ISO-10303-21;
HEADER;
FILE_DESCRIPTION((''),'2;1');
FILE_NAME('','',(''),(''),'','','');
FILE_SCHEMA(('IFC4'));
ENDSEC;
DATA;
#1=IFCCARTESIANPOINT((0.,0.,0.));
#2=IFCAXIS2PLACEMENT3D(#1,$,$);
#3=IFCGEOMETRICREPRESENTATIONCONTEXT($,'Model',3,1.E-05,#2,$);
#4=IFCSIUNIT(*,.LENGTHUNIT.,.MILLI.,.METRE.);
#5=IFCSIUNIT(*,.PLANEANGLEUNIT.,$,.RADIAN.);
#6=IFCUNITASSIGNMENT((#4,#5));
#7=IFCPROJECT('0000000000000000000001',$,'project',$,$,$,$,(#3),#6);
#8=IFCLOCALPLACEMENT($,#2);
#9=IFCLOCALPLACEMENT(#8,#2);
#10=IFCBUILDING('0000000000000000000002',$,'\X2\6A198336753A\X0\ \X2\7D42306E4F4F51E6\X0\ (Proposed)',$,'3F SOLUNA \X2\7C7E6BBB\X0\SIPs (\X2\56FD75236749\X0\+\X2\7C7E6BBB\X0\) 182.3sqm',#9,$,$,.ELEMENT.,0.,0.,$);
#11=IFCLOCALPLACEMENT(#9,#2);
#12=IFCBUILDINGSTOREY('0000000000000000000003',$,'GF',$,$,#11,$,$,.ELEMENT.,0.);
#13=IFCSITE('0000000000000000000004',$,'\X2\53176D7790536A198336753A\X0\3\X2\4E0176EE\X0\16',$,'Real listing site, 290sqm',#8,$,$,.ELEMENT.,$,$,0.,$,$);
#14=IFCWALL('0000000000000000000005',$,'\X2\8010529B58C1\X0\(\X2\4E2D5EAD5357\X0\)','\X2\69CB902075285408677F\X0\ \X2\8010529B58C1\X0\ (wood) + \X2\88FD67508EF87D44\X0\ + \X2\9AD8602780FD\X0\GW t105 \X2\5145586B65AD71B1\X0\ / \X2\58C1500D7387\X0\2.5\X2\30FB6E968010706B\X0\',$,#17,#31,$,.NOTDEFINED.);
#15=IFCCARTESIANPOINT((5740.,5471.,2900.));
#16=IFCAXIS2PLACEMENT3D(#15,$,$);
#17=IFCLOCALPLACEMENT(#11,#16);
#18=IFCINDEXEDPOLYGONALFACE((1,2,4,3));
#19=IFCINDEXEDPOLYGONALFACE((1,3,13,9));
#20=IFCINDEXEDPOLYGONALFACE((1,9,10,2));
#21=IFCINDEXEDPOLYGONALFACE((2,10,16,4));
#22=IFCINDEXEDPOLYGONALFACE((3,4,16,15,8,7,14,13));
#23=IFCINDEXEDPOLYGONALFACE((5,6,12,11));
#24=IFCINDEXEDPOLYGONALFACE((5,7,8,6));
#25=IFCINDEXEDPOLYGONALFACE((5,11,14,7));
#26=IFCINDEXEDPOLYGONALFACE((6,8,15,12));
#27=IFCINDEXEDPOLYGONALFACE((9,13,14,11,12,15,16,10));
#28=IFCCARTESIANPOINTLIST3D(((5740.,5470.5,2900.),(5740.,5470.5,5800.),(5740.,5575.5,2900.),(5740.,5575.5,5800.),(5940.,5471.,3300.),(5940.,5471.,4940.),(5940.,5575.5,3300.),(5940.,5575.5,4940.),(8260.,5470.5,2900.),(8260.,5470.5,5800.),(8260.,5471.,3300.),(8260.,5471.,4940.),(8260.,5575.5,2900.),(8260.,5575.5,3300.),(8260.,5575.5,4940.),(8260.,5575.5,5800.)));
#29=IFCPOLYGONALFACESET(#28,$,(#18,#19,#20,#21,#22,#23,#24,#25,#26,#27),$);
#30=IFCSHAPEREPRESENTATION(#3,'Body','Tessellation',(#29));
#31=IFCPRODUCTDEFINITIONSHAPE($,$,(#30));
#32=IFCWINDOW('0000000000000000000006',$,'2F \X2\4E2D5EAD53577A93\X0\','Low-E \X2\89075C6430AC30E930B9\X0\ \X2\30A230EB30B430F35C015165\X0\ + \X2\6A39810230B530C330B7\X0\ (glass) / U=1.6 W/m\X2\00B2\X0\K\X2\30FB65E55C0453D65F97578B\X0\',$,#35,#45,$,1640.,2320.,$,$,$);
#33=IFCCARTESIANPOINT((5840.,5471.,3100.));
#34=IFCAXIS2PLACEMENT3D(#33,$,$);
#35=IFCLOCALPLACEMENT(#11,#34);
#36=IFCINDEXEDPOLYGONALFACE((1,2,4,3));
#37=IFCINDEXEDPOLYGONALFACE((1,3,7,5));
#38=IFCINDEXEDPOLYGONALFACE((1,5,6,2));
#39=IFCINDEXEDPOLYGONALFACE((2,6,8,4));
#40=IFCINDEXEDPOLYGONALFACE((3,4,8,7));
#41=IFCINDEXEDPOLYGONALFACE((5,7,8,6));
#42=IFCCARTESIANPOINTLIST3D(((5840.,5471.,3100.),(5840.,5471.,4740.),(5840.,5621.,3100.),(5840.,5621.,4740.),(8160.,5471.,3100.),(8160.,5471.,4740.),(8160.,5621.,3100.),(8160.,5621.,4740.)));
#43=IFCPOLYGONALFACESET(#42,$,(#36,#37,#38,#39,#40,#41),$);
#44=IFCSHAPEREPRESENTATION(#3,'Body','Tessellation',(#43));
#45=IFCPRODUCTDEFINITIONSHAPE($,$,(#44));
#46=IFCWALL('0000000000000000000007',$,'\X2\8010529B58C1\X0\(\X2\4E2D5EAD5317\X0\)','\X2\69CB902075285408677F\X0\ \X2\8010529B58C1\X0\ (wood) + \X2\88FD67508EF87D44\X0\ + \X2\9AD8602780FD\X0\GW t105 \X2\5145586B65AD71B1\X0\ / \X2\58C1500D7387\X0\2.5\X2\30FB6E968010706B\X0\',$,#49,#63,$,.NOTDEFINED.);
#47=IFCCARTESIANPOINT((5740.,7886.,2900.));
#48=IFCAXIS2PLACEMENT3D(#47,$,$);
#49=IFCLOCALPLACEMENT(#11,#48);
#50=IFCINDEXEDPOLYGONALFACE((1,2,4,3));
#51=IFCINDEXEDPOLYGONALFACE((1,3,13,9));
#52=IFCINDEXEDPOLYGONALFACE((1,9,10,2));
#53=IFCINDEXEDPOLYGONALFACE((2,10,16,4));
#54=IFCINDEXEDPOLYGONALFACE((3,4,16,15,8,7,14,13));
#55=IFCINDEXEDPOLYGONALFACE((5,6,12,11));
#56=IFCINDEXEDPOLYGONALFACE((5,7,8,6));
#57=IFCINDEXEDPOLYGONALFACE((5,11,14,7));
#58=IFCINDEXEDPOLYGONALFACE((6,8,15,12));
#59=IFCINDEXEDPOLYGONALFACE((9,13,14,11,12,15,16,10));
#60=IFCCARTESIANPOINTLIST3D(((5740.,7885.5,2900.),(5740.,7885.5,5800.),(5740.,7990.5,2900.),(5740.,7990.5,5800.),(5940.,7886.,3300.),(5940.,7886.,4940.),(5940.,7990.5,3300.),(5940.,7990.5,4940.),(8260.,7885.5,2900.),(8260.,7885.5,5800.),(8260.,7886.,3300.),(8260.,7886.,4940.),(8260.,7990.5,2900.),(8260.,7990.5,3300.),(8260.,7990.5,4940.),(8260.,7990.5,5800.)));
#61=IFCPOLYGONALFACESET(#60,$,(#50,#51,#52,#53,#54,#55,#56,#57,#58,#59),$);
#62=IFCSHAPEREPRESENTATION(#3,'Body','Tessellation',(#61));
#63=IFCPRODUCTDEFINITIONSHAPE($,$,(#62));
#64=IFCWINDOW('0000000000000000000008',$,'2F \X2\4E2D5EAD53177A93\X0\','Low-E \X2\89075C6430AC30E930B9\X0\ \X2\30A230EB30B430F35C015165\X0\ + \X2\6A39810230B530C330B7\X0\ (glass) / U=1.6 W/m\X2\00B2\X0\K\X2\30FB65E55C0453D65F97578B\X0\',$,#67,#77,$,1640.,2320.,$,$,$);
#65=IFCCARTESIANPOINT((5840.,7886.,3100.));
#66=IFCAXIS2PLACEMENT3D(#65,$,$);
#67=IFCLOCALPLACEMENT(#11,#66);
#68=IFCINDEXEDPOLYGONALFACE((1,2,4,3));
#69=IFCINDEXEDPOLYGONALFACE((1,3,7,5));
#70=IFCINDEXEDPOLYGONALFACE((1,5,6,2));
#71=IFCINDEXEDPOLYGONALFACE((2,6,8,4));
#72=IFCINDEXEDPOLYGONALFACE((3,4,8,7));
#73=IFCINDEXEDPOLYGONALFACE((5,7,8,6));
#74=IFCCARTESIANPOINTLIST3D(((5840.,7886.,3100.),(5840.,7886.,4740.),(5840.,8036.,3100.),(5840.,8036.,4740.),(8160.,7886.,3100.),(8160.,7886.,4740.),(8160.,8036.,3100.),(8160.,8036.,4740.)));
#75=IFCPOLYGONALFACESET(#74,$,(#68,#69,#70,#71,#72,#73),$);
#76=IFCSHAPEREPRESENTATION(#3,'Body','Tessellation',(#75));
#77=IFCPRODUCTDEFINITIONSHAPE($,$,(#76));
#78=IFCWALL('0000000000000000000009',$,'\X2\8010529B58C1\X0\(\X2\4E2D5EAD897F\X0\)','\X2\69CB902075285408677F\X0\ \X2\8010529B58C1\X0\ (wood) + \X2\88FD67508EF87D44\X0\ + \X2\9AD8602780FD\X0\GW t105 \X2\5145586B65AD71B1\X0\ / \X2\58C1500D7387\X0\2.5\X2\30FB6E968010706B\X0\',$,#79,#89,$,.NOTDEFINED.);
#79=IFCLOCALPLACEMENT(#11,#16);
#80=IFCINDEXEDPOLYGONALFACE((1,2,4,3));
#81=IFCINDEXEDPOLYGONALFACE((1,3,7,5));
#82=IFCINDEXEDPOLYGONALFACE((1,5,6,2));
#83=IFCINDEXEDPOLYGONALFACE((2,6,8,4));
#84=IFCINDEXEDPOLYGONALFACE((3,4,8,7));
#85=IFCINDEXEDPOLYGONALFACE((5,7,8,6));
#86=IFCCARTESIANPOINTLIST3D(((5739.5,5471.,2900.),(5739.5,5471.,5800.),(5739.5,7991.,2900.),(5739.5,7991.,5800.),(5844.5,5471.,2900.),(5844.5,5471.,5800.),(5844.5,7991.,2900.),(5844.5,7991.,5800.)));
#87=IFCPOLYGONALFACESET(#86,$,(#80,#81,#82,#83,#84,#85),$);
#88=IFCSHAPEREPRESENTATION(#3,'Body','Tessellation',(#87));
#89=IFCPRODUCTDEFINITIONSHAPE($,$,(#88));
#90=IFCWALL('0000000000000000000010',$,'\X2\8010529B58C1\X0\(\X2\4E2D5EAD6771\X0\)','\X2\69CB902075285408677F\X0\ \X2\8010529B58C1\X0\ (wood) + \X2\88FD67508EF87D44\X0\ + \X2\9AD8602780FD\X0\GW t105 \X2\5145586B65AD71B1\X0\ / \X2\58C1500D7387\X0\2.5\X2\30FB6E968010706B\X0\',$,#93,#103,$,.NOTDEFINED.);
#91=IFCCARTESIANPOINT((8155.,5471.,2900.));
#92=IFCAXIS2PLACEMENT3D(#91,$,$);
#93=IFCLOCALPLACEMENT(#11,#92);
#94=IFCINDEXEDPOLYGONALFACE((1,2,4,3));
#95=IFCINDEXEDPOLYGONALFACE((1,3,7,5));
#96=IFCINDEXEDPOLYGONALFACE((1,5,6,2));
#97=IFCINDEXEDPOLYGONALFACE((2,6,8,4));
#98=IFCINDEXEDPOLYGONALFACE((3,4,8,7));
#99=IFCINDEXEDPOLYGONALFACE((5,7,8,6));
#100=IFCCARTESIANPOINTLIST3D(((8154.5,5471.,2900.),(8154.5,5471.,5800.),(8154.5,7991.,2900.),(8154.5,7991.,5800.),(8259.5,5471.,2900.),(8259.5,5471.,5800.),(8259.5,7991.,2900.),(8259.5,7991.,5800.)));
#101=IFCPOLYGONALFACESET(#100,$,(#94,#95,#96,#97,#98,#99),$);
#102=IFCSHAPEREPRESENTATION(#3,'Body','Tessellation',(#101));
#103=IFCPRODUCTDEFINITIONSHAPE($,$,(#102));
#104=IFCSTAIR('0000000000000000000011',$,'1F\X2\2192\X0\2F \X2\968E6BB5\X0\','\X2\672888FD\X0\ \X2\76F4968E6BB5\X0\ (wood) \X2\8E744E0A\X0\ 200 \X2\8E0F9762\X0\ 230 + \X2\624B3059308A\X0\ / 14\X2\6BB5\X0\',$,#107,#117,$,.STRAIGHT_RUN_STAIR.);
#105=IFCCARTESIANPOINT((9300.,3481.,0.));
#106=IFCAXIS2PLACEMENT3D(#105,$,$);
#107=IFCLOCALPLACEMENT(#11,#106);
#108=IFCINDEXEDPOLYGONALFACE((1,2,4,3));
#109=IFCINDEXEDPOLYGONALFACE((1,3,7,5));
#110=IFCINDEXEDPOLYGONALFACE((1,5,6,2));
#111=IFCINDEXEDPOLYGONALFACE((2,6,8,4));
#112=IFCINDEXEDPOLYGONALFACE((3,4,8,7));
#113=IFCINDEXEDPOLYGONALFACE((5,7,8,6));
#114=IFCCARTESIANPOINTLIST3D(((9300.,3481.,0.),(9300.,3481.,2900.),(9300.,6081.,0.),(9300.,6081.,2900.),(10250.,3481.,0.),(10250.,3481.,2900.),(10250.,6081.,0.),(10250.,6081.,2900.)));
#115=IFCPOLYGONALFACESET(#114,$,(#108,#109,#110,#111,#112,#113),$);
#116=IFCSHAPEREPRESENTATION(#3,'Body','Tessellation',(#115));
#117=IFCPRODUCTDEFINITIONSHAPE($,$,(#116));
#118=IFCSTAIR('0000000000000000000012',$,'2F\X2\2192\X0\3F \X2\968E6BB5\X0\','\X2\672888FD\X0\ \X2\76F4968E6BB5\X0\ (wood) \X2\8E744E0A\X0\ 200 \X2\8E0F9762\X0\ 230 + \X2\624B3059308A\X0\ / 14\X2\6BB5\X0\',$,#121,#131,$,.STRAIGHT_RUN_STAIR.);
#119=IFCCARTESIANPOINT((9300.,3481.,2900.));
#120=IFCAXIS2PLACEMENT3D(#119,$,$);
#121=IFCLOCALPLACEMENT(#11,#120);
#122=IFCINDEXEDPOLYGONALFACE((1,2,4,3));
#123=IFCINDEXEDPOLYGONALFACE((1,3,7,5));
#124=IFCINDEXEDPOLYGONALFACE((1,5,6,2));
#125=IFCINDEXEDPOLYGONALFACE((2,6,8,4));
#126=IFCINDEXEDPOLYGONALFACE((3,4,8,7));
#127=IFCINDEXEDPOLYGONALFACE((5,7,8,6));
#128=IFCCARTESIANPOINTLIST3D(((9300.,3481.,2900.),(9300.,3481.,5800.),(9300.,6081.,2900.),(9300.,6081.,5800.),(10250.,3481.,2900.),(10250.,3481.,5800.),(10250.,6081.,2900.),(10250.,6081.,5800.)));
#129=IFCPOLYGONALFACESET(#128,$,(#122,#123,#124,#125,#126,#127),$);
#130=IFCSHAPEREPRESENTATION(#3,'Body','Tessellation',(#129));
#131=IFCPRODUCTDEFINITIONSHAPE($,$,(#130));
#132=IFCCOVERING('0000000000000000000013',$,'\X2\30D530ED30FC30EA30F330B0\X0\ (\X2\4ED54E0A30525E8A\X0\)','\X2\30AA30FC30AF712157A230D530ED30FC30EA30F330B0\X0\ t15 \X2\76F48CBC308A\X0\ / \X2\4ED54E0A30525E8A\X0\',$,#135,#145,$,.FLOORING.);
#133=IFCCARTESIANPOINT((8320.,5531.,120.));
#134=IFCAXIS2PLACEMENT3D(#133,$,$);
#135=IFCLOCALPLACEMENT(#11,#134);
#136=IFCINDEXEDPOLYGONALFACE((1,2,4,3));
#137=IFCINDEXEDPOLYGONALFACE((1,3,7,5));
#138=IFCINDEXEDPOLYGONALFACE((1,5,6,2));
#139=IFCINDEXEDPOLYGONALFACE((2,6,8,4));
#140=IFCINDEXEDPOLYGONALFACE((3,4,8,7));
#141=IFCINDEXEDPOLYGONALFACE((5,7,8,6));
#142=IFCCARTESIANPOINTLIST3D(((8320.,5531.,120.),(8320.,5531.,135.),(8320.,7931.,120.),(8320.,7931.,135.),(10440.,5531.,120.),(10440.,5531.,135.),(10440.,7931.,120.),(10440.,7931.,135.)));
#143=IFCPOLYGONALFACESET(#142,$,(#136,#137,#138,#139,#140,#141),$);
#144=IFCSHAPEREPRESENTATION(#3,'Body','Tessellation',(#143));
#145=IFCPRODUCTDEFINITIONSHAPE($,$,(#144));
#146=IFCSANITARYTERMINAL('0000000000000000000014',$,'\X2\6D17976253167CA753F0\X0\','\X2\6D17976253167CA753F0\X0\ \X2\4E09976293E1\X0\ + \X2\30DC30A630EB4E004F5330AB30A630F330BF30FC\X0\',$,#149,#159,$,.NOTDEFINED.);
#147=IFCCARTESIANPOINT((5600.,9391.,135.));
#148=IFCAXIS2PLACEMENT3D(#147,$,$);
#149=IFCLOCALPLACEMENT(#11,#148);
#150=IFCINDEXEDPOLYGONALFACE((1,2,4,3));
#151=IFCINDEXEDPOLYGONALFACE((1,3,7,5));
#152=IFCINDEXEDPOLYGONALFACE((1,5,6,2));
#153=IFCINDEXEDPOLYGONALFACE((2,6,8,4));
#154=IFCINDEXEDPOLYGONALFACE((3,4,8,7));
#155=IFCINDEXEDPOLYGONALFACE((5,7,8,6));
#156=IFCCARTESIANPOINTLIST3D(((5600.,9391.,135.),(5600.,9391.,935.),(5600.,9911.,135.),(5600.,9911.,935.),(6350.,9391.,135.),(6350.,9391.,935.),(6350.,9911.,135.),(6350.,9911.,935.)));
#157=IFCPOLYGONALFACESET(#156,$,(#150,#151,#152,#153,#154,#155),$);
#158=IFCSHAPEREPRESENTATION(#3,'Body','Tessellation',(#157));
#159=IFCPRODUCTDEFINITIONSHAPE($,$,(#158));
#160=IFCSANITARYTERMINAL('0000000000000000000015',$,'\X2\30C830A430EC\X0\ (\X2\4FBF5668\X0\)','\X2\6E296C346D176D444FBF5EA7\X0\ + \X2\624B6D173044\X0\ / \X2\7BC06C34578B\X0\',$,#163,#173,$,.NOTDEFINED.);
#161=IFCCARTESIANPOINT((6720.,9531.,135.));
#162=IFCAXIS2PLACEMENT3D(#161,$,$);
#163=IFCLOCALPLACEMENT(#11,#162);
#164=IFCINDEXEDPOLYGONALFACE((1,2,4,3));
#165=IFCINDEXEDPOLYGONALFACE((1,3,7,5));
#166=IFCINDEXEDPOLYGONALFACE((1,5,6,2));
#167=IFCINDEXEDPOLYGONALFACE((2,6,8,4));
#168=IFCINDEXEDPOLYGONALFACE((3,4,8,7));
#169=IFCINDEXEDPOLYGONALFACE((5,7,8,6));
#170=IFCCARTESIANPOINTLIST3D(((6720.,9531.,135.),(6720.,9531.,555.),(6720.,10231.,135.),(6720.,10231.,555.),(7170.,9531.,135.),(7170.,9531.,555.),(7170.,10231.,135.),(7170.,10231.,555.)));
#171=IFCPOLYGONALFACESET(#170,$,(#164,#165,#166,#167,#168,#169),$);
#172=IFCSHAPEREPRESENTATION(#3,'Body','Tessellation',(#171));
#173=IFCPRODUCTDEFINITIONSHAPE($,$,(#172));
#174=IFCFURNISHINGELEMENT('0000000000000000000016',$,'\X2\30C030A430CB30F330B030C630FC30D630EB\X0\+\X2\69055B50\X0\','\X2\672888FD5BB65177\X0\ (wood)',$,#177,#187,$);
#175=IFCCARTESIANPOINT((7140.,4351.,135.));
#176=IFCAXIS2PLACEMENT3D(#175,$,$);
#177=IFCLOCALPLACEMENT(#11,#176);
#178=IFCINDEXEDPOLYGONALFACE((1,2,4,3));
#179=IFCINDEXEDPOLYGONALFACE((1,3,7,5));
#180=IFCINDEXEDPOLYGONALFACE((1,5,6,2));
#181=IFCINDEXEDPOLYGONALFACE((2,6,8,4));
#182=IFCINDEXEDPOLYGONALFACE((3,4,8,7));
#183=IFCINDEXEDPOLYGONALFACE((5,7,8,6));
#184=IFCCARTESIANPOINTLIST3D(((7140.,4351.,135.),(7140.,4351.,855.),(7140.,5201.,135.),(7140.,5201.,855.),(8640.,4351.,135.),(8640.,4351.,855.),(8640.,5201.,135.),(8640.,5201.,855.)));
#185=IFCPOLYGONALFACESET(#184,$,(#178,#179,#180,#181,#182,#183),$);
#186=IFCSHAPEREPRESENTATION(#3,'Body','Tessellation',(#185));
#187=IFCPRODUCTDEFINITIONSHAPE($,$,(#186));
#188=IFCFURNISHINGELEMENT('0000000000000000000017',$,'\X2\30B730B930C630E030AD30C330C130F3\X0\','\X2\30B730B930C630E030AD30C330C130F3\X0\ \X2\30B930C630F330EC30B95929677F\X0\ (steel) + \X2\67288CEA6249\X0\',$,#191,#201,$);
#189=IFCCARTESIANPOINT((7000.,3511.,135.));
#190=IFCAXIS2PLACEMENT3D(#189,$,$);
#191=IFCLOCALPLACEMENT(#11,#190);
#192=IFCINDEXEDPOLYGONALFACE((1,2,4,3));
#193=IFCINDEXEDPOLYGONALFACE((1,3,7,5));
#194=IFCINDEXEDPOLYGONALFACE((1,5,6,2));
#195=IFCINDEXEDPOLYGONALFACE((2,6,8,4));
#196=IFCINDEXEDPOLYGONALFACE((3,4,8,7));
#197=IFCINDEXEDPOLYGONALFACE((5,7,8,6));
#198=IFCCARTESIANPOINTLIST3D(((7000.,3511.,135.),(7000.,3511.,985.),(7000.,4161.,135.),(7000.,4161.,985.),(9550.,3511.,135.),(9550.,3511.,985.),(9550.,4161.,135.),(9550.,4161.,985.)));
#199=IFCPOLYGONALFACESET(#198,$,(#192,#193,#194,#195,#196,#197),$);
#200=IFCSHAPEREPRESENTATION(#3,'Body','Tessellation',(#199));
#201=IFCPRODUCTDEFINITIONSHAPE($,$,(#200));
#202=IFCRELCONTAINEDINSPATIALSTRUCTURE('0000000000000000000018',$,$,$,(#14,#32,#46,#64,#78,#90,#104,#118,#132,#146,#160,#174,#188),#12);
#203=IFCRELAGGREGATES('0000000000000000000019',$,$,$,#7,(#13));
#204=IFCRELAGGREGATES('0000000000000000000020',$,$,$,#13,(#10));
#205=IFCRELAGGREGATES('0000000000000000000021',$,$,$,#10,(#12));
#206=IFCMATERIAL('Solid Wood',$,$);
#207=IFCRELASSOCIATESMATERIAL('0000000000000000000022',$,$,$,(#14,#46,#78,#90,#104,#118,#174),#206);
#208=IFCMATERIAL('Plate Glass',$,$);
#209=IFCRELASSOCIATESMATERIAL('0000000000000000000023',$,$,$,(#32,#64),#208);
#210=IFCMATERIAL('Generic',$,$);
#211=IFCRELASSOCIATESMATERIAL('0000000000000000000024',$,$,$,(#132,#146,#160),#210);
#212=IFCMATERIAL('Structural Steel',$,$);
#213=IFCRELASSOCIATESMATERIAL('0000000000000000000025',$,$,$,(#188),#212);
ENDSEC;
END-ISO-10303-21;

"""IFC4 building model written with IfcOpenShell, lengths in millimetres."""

from ifc_helpers import new_model, si_unit, frame, frame_2d, origin, place, context, project, spatial, rectangle, extrude, material, element, fill, save


model = new_model("IFC4")

# Units and contexts
model_context = context("Model", 3, precision=1e-05, world=origin())
ifc_project = project(units=[si_unit("LENGTHUNIT", "METRE", prefix="MILLI"), si_unit("PLANEANGLEUNIT", "RADIAN")], contexts=[model_context])

# Site, building, storey
site_placement = place(None, origin())
site = spatial("IfcSite", under=ifc_project, at=site_placement, Name="北海道標茶町3丁目16", ObjectType="Real listing site, 290sqm", CompositionType="ELEMENT", RefElevation=0.0)
building_placement = place(site_placement, origin())
building = spatial("IfcBuilding", under=site, at=building_placement, Name="標茶町 終の住処 (Proposed)", ObjectType="3F SOLUNA 籾殻SIPs (国産杉+籾殻) 182.3sqm", CompositionType="ELEMENT", ElevationOfRefHeight=0.0, ElevationOfTerrain=0.0)
storey_placement = place(building_placement, origin())
storey = spatial("IfcBuildingStorey", under=building, at=storey_placement, Name="GF", CompositionType="ELEMENT", Elevation=0.0)

# Shared definitions
ifc_material_1 = material(Name="Solid Wood")

# Shared definitions
ifc_material_2 = material(Name="Plate Glass")

# Walls, openings, windows
wall_1_placement = place(storey_placement, frame((5740.0, 5471.0, 2900.0)))
wall_1 = element("IfcWall", 1, at=wall_1_placement, inside=storey, material=ifc_material_1, Name="耐力壁(中庭南)", Description="構造用合板 耐力壁 (wood) + 製材軸組 + 高性能GW t105 充填断熱 / 壁倍率2.5・準耐火", PredefinedType="NOTDEFINED", context=model_context, shape_type="SweptSolid", body=[
    extrude(rectangle(XDim=2520.0, YDim=105.0, at=frame_2d((1260.0, 52.0))), frame((5740.0, 5471.0, 2900.0)), (0.0, 0.0, 1.0), 2900.0),
])
opening_1_placement = place(storey_placement, frame((5840.0, 5471.0, 3100.0)))
opening_1 = element("IfcOpeningElement", 2, at=opening_1_placement, cuts=wall_1, PredefinedType="NOTDEFINED", context=model_context, shape_type="SweptSolid", body=[
    extrude(rectangle(XDim=2320.0, YDim=150.0, at=frame_2d((1160.0, 75.0))), frame((5840.0, 5471.0, 3100.0)), (0.0, 0.0, 1.0), 1640.0),
])
window_1_placement = place(storey_placement, frame((5840.0, 5471.0, 3100.0)))
window_1 = element("IfcWindow", 3, at=window_1_placement, inside=storey, material=ifc_material_2, Name="2F 中庭南窓", Description="Low-E 複層ガラス アルゴン封入 + 樹脂サッシ (glass) / U=1.6 W/m²K・日射取得型", OverallHeight=1640.0, OverallWidth=2320.0, context=model_context, shape_type="SweptSolid", body=[
    extrude(rectangle(XDim=2320.0, YDim=150.0, at=frame_2d((1160.0, 75.0))), frame((5840.0, 5471.0, 3100.0)), (0.0, 0.0, 1.0), 1640.0),
])
fill(opening_1, window_1)
wall_2_placement = place(storey_placement, frame((5740.0, 7886.0, 2900.0)))
wall_2 = element("IfcWall", 4, at=wall_2_placement, inside=storey, material=ifc_material_1, Name="耐力壁(中庭北)", Description="構造用合板 耐力壁 (wood) + 製材軸組 + 高性能GW t105 充填断熱 / 壁倍率2.5・準耐火", PredefinedType="NOTDEFINED", context=model_context, shape_type="SweptSolid", body=[
    extrude(rectangle(XDim=2520.0, YDim=105.0, at=frame_2d((1260.0, 52.0))), frame((5740.0, 7886.0, 2900.0)), (0.0, 0.0, 1.0), 2900.0),
])
opening_2_placement = place(storey_placement, frame((5840.0, 7886.0, 3100.0)))
opening_2 = element("IfcOpeningElement", 5, at=opening_2_placement, cuts=wall_2, PredefinedType="NOTDEFINED", context=model_context, shape_type="SweptSolid", body=[
    extrude(rectangle(XDim=2320.0, YDim=150.0, at=frame_2d((1160.0, 75.0))), frame((5840.0, 7886.0, 3100.0)), (0.0, 0.0, 1.0), 1640.0),
])
window_2_placement = place(storey_placement, frame((5840.0, 7886.0, 3100.0)))
window_2 = element("IfcWindow", 6, at=window_2_placement, inside=storey, material=ifc_material_2, Name="2F 中庭北窓", Description="Low-E 複層ガラス アルゴン封入 + 樹脂サッシ (glass) / U=1.6 W/m²K・日射取得型", OverallHeight=1640.0, OverallWidth=2320.0, context=model_context, shape_type="SweptSolid", body=[
    extrude(rectangle(XDim=2320.0, YDim=150.0, at=frame_2d((1160.0, 75.0))), frame((5840.0, 7886.0, 3100.0)), (0.0, 0.0, 1.0), 1640.0),
])
fill(opening_2, window_2)

# Walls
wall_3_placement = place(storey_placement, frame((5740.0, 5471.0, 2900.0)))
element("IfcWall", 7, at=wall_3_placement, inside=storey, material=ifc_material_1, Name="耐力壁(中庭西)", Description="構造用合板 耐力壁 (wood) + 製材軸組 + 高性能GW t105 充填断熱 / 壁倍率2.5・準耐火", PredefinedType="NOTDEFINED", context=model_context, shape_type="SweptSolid", body=[
    extrude(rectangle(XDim=105.0, YDim=2520.0, at=frame_2d((52.0, 1260.0))), frame((5740.0, 5471.0, 2900.0)), (0.0, 0.0, 1.0), 2900.0),
])
wall_4_placement = place(storey_placement, frame((8155.0, 5471.0, 2900.0)))
element("IfcWall", 8, at=wall_4_placement, inside=storey, material=ifc_material_1, Name="耐力壁(中庭東)", Description="構造用合板 耐力壁 (wood) + 製材軸組 + 高性能GW t105 充填断熱 / 壁倍率2.5・準耐火", PredefinedType="NOTDEFINED", context=model_context, shape_type="SweptSolid", body=[
    extrude(rectangle(XDim=105.0, YDim=2520.0, at=frame_2d((52.0, 1260.0))), frame((8155.0, 5471.0, 2900.0)), (0.0, 0.0, 1.0), 2900.0),
])

# Stairs
stair_1_placement = place(storey_placement, frame((9300.0, 3481.0, 0.0)))
element("IfcStair", 9, at=stair_1_placement, inside=storey, material=ifc_material_1, Name="1F→2F 階段", Description="木製 直階段 (wood) 蹴上 200 踏面 230 + 手すり / 14段", PredefinedType="STRAIGHT_RUN_STAIR", context=model_context, shape_type="SweptSolid", body=[
    extrude(rectangle(XDim=950.0, YDim=2600.0, at=frame_2d((475.0, 1300.0))), frame((9300.0, 3481.0, 0.0)), (0.0, 0.0, 1.0), 2900.0),
])
stair_2_placement = place(storey_placement, frame((9300.0, 3481.0, 2900.0)))
element("IfcStair", 10, at=stair_2_placement, inside=storey, material=ifc_material_1, Name="2F→3F 階段", Description="木製 直階段 (wood) 蹴上 200 踏面 230 + 手すり / 14段", PredefinedType="STRAIGHT_RUN_STAIR", context=model_context, shape_type="SweptSolid", body=[
    extrude(rectangle(XDim=950.0, YDim=2600.0, at=frame_2d((475.0, 1300.0))), frame((9300.0, 3481.0, 2900.0)), (0.0, 0.0, 1.0), 2900.0),
])

# Covering
ifc_material_3 = material(Name="Generic")
covering_placement = place(storey_placement, frame((8320.0, 5531.0, 120.0)))
element("IfcCovering", 11, at=covering_placement, inside=storey, material=ifc_material_3, Name="フローリング (仕上げ床)", Description="オーク無垢フローリング t15 直貼り / 仕上げ床", PredefinedType="FLOORING", context=model_context, shape_type="SweptSolid", body=[
    extrude(rectangle(XDim=2120.0, YDim=2400.0, at=frame_2d((1060.0, 1200.0))), frame((8320.0, 5531.0, 120.0)), (0.0, 0.0, 1.0), 15.0),
])

# Sanitary terminals
sanitary_terminal_1_placement = place(storey_placement, frame((5600.0, 9391.0, 135.0)))
element("IfcSanitaryTerminal", 12, at=sanitary_terminal_1_placement, inside=storey, material=ifc_material_3, Name="洗面化粧台", Description="洗面化粧台 三面鏡 + ボウル一体カウンター", PredefinedType="NOTDEFINED", context=model_context, shape_type="SweptSolid", body=[
    extrude(rectangle(XDim=750.0, YDim=520.0, at=frame_2d((375.0, 260.0))), frame((5600.0, 9391.0, 135.0)), (0.0, 0.0, 1.0), 800.0),
])
sanitary_terminal_2_placement = place(storey_placement, frame((6720.0, 9531.0, 135.0)))
element("IfcSanitaryTerminal", 13, at=sanitary_terminal_2_placement, inside=storey, material=ifc_material_3, Name="トイレ (便器)", Description="温水洗浄便座 + 手洗い / 節水型", PredefinedType="NOTDEFINED", context=model_context, shape_type="SweptSolid", body=[
    extrude(rectangle(XDim=450.0, YDim=700.0, at=frame_2d((225.0, 350.0))), frame((6720.0, 9531.0, 135.0)), (0.0, 0.0, 1.0), 420.0),
])

# Furnishing elements
furnishing_1_placement = place(storey_placement, frame((7140.0, 4351.0, 135.0)))
element("IfcFurnishingElement", 14, at=furnishing_1_placement, inside=storey, material=ifc_material_1, Name="ダイニングテーブル+椅子", Description="木製家具 (wood)", context=model_context, shape_type="SweptSolid", body=[
    extrude(rectangle(XDim=1500.0, YDim=850.0, at=frame_2d((750.0, 425.0))), frame((7140.0, 4351.0, 135.0)), (0.0, 0.0, 1.0), 720.0),
])
ifc_material_4 = material(Name="Structural Steel")
furnishing_2_placement = place(storey_placement, frame((7000.0, 3511.0, 135.0)))
element("IfcFurnishingElement", 15, at=furnishing_2_placement, inside=storey, material=ifc_material_4, Name="システムキッチン", Description="システムキッチン ステンレス天板 (steel) + 木質扉", context=model_context, shape_type="SweptSolid", body=[
    extrude(rectangle(XDim=2550.0, YDim=650.0, at=frame_2d((1275.0, 325.0))), frame((7000.0, 3511.0, 135.0)), (0.0, 0.0, 1.0), 850.0),
])

save(model, "model.ifc")
